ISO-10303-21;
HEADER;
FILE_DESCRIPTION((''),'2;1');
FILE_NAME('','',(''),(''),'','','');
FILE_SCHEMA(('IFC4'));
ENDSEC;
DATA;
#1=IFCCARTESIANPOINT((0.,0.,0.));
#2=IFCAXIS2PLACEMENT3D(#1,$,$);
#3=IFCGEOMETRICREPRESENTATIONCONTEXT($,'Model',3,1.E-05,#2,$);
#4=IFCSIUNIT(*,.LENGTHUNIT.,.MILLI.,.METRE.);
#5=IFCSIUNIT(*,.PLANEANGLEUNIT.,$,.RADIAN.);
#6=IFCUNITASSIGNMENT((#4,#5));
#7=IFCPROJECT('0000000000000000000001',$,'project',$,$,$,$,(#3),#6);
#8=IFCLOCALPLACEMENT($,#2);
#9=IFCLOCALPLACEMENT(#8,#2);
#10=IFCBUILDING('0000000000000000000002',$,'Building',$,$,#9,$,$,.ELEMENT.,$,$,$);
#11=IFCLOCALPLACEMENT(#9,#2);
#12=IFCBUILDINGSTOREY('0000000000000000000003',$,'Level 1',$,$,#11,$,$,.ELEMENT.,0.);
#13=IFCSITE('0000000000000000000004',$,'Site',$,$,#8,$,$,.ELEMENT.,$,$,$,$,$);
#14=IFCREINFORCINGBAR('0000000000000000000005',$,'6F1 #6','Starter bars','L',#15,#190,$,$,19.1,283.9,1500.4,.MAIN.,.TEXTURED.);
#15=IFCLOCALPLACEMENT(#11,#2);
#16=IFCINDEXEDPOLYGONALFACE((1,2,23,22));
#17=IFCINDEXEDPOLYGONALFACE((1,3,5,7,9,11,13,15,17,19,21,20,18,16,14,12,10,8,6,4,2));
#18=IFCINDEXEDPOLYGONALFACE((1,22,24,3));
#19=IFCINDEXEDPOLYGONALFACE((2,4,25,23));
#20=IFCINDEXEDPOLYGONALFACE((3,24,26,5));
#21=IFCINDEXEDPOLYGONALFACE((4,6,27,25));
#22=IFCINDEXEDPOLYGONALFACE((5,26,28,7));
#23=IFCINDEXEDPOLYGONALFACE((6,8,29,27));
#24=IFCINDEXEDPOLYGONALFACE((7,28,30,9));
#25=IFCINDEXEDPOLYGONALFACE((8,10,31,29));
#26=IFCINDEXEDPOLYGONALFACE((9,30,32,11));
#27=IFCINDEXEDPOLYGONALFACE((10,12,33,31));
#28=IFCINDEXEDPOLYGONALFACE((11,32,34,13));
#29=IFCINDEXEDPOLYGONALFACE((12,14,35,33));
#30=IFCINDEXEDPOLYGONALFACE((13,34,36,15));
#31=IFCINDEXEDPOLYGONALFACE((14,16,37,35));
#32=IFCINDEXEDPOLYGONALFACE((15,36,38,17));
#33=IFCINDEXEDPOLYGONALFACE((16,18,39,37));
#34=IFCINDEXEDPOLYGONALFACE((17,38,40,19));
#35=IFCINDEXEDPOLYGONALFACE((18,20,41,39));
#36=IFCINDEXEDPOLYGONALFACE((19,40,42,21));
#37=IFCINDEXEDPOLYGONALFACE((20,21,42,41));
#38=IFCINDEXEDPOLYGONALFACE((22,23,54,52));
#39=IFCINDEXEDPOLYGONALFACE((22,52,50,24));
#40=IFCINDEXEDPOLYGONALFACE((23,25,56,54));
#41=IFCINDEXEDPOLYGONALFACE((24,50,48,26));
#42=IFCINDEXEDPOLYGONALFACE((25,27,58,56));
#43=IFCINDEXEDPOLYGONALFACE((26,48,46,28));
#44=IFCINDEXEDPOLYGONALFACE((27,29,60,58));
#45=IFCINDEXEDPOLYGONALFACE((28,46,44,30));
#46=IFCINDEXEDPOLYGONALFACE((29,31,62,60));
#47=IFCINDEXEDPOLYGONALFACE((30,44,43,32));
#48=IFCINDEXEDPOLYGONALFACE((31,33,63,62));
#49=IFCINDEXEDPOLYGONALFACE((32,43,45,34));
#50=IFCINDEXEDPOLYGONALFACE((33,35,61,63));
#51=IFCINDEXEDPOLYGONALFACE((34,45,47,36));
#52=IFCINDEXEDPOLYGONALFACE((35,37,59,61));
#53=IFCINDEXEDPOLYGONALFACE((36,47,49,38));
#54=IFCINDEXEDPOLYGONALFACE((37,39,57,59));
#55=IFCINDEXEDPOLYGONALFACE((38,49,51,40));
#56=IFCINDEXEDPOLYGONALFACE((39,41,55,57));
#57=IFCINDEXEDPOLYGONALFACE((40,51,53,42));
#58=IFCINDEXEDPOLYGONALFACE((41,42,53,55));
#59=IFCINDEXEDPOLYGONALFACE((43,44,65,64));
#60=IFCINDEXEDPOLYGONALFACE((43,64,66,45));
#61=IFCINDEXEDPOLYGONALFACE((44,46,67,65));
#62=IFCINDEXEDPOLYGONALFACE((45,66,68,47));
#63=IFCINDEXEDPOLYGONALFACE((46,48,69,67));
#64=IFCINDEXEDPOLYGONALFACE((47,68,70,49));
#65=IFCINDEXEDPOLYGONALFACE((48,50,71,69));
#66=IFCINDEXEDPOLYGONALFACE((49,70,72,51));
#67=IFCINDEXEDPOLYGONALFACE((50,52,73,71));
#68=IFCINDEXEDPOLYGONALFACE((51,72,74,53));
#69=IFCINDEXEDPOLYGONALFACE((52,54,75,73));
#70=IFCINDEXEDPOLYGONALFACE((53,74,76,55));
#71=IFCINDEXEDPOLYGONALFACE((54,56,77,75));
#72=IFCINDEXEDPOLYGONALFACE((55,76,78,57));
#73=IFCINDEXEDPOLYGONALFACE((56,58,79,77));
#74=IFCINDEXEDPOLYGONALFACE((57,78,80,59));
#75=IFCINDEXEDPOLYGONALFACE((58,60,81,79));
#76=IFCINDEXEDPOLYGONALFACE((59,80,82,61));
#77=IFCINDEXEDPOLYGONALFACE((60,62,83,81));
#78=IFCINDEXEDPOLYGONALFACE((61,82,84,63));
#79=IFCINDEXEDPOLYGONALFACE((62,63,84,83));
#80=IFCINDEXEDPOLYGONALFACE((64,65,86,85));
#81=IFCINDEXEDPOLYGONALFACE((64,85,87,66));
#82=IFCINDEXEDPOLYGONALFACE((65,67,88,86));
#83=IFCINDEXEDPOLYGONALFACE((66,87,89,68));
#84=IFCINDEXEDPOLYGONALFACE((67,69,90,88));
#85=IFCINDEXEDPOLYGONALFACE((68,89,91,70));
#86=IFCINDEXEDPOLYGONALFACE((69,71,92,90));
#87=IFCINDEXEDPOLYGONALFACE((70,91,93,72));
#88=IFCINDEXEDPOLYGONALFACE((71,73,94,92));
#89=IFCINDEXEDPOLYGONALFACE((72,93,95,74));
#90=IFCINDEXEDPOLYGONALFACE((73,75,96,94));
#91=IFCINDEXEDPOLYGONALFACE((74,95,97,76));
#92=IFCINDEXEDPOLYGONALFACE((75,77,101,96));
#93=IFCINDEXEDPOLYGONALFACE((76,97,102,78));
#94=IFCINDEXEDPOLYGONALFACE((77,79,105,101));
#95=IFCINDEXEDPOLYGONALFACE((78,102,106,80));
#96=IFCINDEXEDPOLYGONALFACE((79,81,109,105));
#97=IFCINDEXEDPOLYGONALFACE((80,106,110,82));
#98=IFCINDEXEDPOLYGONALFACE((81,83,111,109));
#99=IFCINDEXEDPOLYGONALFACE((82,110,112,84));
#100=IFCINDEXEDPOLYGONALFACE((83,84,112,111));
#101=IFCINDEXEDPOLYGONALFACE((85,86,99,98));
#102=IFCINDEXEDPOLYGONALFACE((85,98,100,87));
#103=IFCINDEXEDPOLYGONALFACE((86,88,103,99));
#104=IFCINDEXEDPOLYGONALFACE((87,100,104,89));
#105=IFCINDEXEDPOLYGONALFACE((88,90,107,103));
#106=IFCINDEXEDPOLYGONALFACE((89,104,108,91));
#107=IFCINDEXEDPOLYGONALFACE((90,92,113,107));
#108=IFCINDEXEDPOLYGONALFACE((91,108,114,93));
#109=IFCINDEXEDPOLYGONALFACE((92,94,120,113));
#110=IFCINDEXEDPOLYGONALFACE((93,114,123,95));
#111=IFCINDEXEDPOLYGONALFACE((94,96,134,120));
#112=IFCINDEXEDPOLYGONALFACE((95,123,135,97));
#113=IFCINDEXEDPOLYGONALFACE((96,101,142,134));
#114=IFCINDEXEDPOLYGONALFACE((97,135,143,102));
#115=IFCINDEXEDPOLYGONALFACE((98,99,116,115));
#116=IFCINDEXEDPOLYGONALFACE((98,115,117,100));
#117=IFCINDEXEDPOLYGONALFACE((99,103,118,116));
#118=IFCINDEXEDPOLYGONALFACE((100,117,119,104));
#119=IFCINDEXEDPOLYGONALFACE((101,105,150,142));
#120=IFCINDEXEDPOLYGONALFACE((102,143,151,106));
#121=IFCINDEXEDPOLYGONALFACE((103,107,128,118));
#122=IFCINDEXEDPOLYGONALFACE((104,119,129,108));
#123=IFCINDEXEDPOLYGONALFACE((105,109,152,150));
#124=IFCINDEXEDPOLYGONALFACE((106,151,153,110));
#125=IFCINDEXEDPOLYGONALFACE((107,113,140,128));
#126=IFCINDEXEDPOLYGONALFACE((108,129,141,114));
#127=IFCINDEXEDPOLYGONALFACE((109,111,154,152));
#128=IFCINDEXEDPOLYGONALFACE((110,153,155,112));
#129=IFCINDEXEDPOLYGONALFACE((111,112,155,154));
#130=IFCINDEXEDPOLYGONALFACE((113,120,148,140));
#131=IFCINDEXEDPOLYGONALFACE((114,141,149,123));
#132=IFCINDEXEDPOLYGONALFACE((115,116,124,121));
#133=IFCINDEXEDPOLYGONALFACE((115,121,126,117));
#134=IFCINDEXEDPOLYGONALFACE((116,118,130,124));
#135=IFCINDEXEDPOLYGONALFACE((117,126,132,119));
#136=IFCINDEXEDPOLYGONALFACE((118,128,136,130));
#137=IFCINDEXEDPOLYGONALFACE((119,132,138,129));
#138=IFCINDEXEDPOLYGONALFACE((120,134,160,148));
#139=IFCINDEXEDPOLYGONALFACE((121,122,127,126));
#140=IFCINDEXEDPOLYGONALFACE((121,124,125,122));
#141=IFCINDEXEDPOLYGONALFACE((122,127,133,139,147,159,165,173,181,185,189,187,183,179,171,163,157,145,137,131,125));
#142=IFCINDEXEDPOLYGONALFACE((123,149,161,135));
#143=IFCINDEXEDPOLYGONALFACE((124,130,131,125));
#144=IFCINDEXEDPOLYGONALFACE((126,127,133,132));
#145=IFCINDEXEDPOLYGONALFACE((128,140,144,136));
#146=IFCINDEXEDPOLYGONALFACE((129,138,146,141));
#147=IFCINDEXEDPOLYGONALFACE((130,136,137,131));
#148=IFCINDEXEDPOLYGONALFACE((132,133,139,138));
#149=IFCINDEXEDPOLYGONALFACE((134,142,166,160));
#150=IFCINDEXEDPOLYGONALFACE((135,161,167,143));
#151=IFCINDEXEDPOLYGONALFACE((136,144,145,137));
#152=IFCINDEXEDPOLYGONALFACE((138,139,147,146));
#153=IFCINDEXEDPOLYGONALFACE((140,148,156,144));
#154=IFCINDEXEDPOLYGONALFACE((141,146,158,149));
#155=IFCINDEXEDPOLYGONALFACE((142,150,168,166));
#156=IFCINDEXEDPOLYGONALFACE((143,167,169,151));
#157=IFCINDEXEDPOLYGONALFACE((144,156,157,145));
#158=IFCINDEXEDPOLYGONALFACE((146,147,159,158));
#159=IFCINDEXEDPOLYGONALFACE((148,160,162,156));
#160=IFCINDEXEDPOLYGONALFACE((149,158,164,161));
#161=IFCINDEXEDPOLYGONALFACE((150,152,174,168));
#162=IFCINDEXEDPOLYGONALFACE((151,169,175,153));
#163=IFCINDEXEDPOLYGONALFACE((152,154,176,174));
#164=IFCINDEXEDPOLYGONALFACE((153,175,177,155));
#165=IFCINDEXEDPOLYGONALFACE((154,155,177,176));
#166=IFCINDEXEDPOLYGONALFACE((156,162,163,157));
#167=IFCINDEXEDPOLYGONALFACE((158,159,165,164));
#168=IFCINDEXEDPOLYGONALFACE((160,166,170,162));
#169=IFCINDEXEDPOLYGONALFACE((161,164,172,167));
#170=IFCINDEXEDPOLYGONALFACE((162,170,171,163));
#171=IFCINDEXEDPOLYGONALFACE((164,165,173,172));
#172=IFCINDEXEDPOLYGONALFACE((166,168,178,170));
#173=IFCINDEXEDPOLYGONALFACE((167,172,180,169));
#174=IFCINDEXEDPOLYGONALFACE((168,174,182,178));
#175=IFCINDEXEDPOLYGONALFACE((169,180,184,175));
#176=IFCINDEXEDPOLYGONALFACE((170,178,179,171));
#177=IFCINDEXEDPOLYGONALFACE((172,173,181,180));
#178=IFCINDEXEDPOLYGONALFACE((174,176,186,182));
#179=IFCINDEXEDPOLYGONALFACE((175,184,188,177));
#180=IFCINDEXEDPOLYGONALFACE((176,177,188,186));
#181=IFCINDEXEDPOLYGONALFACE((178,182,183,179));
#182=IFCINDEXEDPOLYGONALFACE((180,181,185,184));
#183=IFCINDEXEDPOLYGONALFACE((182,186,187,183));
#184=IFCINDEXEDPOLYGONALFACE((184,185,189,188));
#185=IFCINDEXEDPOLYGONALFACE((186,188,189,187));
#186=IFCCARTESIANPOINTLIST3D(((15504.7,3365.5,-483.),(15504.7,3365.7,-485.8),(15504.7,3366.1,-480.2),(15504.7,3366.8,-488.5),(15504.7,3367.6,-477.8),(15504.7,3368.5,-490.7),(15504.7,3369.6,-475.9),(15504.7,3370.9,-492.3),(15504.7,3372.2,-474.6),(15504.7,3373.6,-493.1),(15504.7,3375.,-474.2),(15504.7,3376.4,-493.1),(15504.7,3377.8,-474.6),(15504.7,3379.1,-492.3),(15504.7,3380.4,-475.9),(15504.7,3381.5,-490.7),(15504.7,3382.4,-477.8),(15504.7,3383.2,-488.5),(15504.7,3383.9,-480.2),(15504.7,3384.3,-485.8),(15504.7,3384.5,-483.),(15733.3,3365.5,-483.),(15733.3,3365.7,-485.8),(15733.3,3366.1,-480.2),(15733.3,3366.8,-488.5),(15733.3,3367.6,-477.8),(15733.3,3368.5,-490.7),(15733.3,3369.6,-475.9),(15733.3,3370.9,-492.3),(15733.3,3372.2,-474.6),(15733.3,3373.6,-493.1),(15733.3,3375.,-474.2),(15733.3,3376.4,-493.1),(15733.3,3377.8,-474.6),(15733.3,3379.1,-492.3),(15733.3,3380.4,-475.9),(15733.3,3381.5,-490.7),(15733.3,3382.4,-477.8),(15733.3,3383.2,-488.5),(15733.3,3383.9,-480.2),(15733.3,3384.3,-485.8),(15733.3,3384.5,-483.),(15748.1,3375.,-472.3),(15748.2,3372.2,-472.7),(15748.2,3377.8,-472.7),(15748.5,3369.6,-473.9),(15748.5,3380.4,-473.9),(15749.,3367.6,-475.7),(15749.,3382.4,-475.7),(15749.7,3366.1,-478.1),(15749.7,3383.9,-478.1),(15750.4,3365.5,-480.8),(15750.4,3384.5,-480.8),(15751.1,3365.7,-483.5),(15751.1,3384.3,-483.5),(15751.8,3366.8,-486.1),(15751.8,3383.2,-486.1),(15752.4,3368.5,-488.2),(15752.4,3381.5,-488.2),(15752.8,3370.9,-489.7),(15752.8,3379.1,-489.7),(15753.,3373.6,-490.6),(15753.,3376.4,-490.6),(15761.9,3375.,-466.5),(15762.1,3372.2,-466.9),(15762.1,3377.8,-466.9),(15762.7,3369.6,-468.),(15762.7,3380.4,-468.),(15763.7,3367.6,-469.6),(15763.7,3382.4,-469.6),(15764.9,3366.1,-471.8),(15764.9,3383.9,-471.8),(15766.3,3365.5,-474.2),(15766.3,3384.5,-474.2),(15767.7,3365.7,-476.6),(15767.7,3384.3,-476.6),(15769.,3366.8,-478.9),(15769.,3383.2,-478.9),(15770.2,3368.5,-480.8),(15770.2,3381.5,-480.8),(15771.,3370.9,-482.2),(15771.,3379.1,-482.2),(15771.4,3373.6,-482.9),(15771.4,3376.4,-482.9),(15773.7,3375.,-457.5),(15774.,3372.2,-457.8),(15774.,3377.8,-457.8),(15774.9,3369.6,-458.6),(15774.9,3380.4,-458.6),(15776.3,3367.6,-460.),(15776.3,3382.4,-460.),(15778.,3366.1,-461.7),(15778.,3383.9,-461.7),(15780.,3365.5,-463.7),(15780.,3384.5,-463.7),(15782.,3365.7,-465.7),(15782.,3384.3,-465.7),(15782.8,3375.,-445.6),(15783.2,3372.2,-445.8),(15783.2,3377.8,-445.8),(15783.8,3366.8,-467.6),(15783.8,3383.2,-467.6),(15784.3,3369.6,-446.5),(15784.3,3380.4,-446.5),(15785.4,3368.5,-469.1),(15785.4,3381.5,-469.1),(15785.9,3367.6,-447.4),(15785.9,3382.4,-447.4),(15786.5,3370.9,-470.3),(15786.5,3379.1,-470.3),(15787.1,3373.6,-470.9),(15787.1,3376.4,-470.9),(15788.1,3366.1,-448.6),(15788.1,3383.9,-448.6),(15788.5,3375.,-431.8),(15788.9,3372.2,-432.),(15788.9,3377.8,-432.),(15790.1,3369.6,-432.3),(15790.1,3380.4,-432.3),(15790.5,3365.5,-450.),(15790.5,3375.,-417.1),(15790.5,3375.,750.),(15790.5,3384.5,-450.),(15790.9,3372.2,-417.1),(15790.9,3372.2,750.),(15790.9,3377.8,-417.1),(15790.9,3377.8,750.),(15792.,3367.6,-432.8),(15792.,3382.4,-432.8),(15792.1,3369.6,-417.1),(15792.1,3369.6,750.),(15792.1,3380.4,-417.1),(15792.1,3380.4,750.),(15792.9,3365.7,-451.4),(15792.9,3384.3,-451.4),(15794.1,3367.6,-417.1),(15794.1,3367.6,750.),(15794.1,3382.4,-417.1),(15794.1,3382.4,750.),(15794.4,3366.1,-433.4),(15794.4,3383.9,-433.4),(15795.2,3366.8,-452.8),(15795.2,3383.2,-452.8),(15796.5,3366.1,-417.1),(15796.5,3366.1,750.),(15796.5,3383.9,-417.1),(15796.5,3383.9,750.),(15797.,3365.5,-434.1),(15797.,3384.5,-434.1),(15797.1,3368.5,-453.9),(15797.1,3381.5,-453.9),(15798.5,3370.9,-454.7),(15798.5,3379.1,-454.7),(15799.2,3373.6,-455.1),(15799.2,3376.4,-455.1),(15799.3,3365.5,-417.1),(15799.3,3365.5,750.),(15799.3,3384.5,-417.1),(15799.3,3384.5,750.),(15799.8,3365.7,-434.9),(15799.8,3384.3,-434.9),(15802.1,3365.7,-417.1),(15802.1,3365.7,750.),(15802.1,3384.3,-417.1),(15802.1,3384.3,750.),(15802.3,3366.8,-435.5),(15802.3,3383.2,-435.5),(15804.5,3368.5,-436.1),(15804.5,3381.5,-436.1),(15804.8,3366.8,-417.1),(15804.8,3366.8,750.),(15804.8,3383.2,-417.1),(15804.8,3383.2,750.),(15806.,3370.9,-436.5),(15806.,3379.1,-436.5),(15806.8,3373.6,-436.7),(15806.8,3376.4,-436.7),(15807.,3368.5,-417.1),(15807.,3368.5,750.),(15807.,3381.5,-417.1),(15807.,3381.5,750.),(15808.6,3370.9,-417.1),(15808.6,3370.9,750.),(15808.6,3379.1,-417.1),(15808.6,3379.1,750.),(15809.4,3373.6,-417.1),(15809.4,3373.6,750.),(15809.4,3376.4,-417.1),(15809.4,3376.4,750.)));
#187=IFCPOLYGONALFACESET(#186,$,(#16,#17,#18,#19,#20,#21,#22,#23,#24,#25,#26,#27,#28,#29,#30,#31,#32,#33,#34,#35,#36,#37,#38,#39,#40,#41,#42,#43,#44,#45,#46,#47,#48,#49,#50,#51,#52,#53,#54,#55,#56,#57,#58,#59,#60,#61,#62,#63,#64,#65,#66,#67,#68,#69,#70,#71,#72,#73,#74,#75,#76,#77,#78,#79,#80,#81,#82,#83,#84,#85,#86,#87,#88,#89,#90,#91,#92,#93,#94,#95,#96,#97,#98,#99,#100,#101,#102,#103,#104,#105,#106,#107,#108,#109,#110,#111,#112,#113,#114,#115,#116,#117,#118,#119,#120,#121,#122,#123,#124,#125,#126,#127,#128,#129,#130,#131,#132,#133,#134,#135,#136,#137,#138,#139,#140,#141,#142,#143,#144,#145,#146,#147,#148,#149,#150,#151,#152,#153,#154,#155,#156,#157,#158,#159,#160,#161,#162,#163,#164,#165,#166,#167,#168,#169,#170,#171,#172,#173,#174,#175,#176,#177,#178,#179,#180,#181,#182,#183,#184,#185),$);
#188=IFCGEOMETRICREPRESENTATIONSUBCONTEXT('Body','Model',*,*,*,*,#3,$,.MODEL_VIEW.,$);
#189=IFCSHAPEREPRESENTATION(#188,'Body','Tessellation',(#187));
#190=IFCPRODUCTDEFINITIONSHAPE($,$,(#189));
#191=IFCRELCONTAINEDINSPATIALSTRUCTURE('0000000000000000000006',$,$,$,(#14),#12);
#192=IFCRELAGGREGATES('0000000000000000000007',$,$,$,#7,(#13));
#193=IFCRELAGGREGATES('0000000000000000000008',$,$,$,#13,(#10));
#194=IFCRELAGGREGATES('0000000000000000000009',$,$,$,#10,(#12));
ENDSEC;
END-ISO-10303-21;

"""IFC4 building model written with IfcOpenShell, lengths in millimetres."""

from ifc_helpers import new_model, entity, si_unit, origin, place, context, subcontext, project, spatial, element, save


model = new_model("IFC4")

# Units and contexts
model_context = context("Model", 3, precision=1e-05, world=origin())
body_context = subcontext(model_context, "Body", "Model", "MODEL_VIEW")
ifc_project = project(units=[si_unit("LENGTHUNIT", "METRE", prefix="MILLI"), si_unit("PLANEANGLEUNIT", "RADIAN")], contexts=[model_context])

# Site, building, storey
site_placement = place(None, origin())
site = spatial("IfcSite", under=ifc_project, at=site_placement, Name="Site", CompositionType="ELEMENT")
building_placement = place(site_placement, origin())
building = spatial("IfcBuilding", under=site, at=building_placement, Name="Building", CompositionType="ELEMENT")
storey_placement = place(building_placement, origin())
storey = spatial("IfcBuildingStorey", under=building, at=storey_placement, Name="Level 1", CompositionType="ELEMENT", Elevation=0.0)

# Reinforcing bar
reinforcing_bar_1_placement = place(storey_placement, origin())
element("IfcReinforcingBar", 1, at=reinforcing_bar_1_placement, inside=storey, Name="6F1 #6", Description="Starter bars", ObjectType="L", BarLength=1500.4, BarSurface="TEXTURED", CrossSectionArea=283.9, NominalDiameter=19.1, PredefinedType="MAIN", context=body_context, shape_type="AdvancedSweptSolid", body=[
    entity("IfcSweptDiskSolid", entity("IfcIndexedPolyCurve", entity("IfcCartesianPointList3D", [[15800.0, 3375.0, 750.0], [15800.0, 3375.0, -417.1], [15780.5, 3375.0, -464.2], [15733.3, 3375.0, -483.7], [15504.7, 3375.0, -483.7]]), [entity("IfcLineIndex", [1, 2]), entity("IfcArcIndex", [2, 3, 4]), entity("IfcLineIndex", [4, 5])], False), 9.5),
])

save(model, "model.ifc")
